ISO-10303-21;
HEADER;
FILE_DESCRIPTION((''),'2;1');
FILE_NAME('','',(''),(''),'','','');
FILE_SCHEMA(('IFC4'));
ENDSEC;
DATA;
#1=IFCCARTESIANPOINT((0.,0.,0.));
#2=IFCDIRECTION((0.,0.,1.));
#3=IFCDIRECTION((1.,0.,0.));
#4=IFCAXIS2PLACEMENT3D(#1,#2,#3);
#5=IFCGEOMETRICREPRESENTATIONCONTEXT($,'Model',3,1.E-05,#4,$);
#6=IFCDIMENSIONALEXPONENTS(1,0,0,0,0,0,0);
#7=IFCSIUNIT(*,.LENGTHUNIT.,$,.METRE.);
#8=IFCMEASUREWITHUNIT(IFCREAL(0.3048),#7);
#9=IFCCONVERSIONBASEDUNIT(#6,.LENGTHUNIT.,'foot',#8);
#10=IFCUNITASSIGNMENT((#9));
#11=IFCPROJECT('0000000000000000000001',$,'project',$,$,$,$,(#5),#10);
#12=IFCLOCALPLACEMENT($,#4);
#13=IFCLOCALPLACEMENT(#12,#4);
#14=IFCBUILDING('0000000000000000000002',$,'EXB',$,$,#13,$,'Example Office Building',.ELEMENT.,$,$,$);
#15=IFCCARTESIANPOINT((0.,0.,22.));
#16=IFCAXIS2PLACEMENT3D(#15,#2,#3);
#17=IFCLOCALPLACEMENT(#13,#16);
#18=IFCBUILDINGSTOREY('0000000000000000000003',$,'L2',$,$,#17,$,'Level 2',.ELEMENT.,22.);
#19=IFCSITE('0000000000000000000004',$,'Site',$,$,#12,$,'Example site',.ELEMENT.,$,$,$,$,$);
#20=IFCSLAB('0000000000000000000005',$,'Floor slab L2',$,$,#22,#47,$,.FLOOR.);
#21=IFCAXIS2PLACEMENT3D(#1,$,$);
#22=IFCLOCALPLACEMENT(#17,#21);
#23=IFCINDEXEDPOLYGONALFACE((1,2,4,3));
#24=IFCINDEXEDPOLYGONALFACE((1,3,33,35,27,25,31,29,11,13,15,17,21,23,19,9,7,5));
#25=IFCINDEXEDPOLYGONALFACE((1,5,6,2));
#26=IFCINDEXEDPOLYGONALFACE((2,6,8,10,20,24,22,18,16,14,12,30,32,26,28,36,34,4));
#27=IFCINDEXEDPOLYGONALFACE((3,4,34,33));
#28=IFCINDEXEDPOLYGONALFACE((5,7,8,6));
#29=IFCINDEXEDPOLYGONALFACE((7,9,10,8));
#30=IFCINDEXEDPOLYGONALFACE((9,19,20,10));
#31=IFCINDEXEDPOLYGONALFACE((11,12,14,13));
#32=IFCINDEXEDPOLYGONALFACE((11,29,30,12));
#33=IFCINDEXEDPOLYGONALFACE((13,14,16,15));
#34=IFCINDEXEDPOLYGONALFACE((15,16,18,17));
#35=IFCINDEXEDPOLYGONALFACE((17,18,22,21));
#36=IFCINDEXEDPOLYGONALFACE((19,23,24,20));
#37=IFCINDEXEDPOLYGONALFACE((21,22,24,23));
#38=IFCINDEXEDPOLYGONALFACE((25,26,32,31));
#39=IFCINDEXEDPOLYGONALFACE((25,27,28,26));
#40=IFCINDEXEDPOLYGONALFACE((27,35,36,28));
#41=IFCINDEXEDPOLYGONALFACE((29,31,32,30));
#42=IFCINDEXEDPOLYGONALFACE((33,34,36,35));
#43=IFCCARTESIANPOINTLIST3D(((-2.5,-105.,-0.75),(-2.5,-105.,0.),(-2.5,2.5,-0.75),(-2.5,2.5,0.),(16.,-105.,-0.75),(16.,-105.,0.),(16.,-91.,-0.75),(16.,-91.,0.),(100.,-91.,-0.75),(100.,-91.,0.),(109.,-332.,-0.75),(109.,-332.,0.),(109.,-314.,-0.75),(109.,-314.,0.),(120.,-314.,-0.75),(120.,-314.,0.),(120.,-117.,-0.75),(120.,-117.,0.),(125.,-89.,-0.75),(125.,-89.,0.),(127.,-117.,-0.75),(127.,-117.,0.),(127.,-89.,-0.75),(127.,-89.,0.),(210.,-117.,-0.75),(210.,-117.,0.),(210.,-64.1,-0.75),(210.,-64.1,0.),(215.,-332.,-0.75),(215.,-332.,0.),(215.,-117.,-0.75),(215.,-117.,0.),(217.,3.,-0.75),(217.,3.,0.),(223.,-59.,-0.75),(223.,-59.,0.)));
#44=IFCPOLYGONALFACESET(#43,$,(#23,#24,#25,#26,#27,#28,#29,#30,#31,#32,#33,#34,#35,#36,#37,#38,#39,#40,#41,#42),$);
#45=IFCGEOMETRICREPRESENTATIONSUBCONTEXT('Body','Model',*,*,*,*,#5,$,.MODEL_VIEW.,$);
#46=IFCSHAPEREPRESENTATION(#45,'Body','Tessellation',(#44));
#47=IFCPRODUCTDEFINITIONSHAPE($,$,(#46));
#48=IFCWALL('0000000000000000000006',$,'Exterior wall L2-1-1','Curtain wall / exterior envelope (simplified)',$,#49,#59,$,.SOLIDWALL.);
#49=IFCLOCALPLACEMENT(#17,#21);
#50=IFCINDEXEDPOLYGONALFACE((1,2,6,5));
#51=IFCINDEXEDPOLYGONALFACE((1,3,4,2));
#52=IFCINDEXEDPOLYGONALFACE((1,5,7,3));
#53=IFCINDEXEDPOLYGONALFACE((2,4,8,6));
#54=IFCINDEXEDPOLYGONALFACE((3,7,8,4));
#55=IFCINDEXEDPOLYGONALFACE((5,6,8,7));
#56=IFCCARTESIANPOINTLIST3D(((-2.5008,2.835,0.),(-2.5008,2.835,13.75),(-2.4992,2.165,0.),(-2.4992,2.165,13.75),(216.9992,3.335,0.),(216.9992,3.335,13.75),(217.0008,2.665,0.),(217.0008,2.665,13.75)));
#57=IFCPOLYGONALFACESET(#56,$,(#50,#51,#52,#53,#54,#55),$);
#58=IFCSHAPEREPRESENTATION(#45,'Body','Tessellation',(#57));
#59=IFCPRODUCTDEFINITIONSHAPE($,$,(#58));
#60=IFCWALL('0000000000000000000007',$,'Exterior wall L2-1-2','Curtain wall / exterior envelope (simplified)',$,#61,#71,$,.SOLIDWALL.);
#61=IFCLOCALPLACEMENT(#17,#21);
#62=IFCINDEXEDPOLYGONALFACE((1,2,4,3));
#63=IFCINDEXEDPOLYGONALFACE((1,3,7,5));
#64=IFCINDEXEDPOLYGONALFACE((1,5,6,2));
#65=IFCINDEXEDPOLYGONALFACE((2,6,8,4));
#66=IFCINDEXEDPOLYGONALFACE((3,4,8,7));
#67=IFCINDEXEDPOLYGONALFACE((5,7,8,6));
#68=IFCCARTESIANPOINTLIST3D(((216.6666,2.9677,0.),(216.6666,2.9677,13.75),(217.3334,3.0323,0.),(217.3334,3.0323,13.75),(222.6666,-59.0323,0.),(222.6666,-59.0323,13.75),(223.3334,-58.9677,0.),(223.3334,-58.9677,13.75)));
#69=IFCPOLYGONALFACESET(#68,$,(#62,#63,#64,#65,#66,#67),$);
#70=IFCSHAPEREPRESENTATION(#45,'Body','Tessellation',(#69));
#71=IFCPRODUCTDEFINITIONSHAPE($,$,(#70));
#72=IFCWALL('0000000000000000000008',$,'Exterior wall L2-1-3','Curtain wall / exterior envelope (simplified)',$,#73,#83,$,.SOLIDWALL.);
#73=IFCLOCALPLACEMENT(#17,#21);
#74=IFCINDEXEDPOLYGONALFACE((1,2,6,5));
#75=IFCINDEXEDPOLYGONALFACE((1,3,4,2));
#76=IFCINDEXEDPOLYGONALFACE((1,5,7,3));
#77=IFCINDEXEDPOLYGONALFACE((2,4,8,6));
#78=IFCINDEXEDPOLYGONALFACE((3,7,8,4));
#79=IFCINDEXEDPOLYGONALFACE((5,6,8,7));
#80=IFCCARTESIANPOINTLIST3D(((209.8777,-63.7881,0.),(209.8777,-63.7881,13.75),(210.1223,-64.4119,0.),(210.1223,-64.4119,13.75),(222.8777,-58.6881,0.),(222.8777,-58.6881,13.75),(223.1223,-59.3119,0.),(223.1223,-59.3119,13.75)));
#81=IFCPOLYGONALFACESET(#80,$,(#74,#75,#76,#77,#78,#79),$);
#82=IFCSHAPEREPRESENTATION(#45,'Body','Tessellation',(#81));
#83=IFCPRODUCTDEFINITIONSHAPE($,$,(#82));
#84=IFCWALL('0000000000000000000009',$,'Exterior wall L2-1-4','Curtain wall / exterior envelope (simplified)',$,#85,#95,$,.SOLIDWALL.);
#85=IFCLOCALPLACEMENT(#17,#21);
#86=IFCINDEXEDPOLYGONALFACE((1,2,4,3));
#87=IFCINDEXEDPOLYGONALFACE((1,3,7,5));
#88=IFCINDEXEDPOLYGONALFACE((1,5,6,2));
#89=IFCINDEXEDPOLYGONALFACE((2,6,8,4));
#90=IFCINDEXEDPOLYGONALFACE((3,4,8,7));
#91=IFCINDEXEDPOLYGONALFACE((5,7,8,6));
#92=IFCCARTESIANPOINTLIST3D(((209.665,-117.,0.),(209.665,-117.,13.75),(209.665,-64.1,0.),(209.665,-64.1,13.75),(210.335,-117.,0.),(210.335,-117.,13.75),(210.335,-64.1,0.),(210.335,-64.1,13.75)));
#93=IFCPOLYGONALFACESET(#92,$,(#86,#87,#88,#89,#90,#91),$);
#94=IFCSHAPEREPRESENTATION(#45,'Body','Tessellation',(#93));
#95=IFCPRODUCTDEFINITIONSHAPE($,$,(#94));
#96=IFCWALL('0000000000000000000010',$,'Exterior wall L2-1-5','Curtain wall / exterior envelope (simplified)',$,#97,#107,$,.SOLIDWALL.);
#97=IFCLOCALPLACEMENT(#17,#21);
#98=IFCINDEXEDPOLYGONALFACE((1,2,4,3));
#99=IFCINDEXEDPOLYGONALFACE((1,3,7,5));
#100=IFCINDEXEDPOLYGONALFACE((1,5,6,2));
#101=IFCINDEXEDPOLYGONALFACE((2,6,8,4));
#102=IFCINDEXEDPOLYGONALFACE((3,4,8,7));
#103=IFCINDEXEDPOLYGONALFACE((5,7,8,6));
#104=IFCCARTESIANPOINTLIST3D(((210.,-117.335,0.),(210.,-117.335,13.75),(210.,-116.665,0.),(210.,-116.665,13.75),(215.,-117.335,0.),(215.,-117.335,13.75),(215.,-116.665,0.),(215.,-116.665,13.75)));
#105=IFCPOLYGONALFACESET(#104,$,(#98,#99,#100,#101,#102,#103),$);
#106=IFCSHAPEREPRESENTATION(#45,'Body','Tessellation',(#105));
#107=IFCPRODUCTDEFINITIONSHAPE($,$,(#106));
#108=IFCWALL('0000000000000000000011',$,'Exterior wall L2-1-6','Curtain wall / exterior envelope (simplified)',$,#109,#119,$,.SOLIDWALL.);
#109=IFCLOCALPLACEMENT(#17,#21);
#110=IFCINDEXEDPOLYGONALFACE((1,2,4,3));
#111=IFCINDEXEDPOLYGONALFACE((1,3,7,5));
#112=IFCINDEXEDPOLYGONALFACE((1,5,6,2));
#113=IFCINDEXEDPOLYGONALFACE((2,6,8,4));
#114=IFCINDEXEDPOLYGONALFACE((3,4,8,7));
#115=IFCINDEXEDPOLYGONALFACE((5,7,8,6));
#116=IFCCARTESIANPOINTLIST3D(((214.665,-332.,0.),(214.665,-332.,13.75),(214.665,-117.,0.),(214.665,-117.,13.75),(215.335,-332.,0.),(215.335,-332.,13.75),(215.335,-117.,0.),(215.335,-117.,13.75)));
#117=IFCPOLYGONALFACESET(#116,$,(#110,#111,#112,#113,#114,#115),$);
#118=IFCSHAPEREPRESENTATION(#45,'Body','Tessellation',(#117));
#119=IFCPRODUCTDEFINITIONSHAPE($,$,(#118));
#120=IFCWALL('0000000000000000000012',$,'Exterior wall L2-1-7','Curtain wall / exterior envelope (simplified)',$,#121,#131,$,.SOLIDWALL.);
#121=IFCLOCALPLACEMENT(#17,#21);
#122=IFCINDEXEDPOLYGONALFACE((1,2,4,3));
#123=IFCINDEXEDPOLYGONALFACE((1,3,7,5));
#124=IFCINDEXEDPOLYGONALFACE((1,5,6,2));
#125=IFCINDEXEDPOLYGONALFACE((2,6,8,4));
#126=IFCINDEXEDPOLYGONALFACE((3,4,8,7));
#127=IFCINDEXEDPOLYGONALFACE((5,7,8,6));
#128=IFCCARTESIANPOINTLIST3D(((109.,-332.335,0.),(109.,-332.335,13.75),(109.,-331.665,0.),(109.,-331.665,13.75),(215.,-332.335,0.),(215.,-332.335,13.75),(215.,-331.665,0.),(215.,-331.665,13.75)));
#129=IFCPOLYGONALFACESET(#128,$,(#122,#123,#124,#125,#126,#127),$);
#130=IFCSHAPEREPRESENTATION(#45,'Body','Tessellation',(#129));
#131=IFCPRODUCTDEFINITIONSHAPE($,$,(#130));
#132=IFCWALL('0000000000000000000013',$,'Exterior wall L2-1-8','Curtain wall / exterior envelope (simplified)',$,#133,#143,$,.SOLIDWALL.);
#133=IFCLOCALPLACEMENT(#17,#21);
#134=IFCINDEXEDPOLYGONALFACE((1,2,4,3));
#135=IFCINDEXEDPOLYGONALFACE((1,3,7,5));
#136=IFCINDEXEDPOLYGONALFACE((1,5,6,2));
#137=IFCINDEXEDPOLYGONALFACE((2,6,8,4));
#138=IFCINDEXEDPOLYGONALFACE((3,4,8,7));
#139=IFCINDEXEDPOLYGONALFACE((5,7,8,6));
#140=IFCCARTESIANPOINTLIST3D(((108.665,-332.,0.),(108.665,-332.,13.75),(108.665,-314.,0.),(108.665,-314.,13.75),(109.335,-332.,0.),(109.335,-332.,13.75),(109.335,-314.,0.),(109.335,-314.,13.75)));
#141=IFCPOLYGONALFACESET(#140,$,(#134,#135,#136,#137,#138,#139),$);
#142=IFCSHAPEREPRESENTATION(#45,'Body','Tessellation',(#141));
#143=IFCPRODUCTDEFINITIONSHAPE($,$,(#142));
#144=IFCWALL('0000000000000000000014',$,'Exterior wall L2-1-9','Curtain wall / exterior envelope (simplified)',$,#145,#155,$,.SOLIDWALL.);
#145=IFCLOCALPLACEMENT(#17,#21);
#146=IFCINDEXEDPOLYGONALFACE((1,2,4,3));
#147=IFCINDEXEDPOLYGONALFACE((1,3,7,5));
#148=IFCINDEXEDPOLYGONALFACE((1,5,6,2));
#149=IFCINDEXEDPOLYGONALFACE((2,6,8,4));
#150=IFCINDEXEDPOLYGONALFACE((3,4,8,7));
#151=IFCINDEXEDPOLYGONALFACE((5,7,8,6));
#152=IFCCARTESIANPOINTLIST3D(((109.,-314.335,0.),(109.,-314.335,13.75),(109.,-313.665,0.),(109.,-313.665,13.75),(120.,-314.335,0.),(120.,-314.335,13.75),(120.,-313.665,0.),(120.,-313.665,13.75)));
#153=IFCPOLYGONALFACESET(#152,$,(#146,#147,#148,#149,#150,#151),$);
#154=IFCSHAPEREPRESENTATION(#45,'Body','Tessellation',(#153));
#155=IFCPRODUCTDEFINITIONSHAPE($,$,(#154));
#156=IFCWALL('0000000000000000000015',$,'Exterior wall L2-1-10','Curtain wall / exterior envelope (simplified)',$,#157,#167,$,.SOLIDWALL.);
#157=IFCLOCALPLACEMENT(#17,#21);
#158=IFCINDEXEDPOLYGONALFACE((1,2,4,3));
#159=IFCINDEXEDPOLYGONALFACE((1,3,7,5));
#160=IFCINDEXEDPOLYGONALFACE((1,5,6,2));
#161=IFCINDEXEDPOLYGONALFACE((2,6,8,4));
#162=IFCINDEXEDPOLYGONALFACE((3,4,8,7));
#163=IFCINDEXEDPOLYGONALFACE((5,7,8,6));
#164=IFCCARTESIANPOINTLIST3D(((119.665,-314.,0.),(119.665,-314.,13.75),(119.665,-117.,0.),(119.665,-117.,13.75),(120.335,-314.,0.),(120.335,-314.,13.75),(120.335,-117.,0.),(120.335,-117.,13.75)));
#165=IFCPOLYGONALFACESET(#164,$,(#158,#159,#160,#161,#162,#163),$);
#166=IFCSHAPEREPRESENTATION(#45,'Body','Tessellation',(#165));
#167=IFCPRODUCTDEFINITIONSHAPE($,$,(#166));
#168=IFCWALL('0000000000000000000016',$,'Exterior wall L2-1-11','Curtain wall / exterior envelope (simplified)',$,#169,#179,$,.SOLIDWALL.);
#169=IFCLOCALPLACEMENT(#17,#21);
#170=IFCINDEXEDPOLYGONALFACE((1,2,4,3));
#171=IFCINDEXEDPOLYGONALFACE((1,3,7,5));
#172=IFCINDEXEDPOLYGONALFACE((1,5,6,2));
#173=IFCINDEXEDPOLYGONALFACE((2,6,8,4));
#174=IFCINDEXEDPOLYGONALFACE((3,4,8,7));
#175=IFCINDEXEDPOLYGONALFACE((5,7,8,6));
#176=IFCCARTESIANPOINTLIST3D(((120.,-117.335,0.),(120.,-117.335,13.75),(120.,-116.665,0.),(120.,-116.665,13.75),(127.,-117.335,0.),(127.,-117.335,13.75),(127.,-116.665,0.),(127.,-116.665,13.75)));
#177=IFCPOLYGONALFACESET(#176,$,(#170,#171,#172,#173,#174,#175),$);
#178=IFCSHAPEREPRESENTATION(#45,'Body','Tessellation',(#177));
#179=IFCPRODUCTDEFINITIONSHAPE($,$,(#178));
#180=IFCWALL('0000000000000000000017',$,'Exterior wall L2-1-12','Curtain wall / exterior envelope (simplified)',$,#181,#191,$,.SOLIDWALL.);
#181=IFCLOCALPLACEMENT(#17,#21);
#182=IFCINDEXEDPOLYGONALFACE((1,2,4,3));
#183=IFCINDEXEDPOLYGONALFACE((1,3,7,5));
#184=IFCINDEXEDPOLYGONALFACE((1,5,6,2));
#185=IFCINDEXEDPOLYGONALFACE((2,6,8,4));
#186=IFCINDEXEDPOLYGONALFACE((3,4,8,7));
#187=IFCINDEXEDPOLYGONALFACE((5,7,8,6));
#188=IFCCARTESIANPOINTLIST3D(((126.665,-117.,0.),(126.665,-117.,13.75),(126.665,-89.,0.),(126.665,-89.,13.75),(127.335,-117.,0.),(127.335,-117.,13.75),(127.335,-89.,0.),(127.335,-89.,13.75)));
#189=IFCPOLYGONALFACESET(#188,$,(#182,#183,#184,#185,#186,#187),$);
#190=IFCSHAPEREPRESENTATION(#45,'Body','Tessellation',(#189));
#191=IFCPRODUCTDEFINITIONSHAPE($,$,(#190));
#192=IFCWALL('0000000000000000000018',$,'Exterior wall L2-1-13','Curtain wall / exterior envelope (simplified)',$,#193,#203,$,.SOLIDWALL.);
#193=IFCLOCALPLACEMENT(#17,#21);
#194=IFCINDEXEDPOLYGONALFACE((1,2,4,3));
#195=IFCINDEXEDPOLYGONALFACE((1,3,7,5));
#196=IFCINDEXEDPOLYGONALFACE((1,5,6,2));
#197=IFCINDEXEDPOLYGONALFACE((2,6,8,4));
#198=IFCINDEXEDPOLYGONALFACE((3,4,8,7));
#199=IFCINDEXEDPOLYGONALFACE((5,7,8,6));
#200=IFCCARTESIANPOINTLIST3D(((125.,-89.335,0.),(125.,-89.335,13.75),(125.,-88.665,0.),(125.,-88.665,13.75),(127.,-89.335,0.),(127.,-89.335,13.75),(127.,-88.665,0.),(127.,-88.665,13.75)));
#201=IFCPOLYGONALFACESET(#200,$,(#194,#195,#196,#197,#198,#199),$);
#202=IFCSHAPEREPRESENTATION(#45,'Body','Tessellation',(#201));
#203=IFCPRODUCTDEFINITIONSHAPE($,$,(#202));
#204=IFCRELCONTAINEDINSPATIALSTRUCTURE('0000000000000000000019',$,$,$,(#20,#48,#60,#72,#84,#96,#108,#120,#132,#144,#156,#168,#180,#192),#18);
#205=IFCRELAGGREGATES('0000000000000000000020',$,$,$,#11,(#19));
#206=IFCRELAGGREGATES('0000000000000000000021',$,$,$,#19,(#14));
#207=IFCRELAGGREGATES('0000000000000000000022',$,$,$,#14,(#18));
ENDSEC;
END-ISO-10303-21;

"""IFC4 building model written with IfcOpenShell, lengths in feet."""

from ifc_helpers import new_model, entity, si_unit, converted_unit, frame, frame_2d, origin, origin_with_axes, place, context, subcontext, project, spatial, polyline, rectangle, outline, extrude, element, save


model = new_model("IFC4")

# Units and contexts
model_context = context("Model", 3, precision=1e-05, world=origin_with_axes())
body_context = subcontext(model_context, "Body", "Model", "MODEL_VIEW")
ifc_project = project(units=[converted_unit("LENGTHUNIT", "foot", entity("IfcReal", 0.3048), si_unit("LENGTHUNIT", "METRE"), dimensions=[1, 0, 0, 0, 0, 0, 0])], contexts=[model_context])

# Site, building, storey
site_placement = place(None, origin_with_axes())
site = spatial("IfcSite", under=ifc_project, at=site_placement, Name="Site", LongName="Example site", CompositionType="ELEMENT")
building_placement = place(site_placement, origin_with_axes())
building = spatial("IfcBuilding", under=site, at=building_placement, Name="EXB", LongName="Example Office Building", CompositionType="ELEMENT")
storey_placement = place(building_placement, frame((0.0, 0.0, 22.0), z_axis=(0.0, 0.0, 1.0), x_axis=(1.0, 0.0, 0.0)))
storey = spatial("IfcBuildingStorey", under=building, at=storey_placement, Name="L2", LongName="Level 2", CompositionType="ELEMENT", Elevation=22.0)

# Slab
slab_placement = place(storey_placement, origin_with_axes())
element("IfcSlab", 1, at=slab_placement, inside=storey, Name="Floor slab L2", PredefinedType="FLOOR", context=body_context, shape_type="SweptSolid", body=[
    extrude(outline(polyline([(-2.5, 2.5), (217.0, 3.0), (223.0, -59.0), (210.0, -64.1), (210.0, -117.0), (215.0, -117.0), (215.0, -332.0), (109.0, -332.0), (109.0, -314.0), (120.0, -314.0), (120.0, -117.0), (127.0, -117.0), (127.0, -89.0), (125.0, -89.0), (100.0, -91.0), (16.0, -91.0), (16.0, -105.0), (-2.5, -105.0), (-2.5, 2.5)])), frame((0.0, 0.0, -0.75)), (0.0, 0.0, 1.0), 0.75),
])

# Walls
wall_1_placement = place(storey_placement, frame((-2.5, 2.5, 0.0), z_axis=(0.0, 0.0, 1.0), x_axis=(0.999997, 0.002278, 0.0)))
element("IfcWall", 2, at=wall_1_placement, inside=storey, Name="Exterior wall L2-1-1", Description="Curtain wall / exterior envelope (simplified)", PredefinedType="SOLIDWALL", context=body_context, shape_type="SweptSolid", body=[
    extrude(rectangle(XDim=219.5006, YDim=0.67, at=frame_2d((109.7503, 0.0))), origin(), (0.0, 0.0, 1.0), 13.75),
])
wall_2_placement = place(storey_placement, frame((217.0, 3.0, 0.0), z_axis=(0.0, 0.0, 1.0), x_axis=(0.096324, -0.99535, 0.0)))
element("IfcWall", 3, at=wall_2_placement, inside=storey, Name="Exterior wall L2-1-2", Description="Curtain wall / exterior envelope (simplified)", PredefinedType="SOLIDWALL", context=body_context, shape_type="SweptSolid", body=[
    extrude(rectangle(XDim=62.2896, YDim=0.67, at=frame_2d((31.1448, 0.0))), origin(), (0.0, 0.0, 1.0), 13.75),
])
wall_3_placement = place(storey_placement, frame((223.0, -59.0, 0.0), z_axis=(0.0, 0.0, 1.0), x_axis=(-0.930925, -0.365209, 0.0)))
element("IfcWall", 4, at=wall_3_placement, inside=storey, Name="Exterior wall L2-1-3", Description="Curtain wall / exterior envelope (simplified)", PredefinedType="SOLIDWALL", context=body_context, shape_type="SweptSolid", body=[
    extrude(rectangle(XDim=13.9646, YDim=0.67, at=frame_2d((6.9823, 0.0))), origin(), (0.0, 0.0, 1.0), 13.75),
])
wall_4_placement = place(storey_placement, frame((210.0, -64.1, 0.0), z_axis=(0.0, 0.0, 1.0), x_axis=(0.0, -1.0, 0.0)))
element("IfcWall", 5, at=wall_4_placement, inside=storey, Name="Exterior wall L2-1-4", Description="Curtain wall / exterior envelope (simplified)", PredefinedType="SOLIDWALL", context=body_context, shape_type="SweptSolid", body=[
    extrude(rectangle(XDim=52.9, YDim=0.67, at=frame_2d((26.45, 0.0))), origin(), (0.0, 0.0, 1.0), 13.75),
])
wall_5_placement = place(storey_placement, frame((210.0, -117.0, 0.0), z_axis=(0.0, 0.0, 1.0), x_axis=(1.0, 0.0, 0.0)))
element("IfcWall", 6, at=wall_5_placement, inside=storey, Name="Exterior wall L2-1-5", Description="Curtain wall / exterior envelope (simplified)", PredefinedType="SOLIDWALL", context=body_context, shape_type="SweptSolid", body=[
    extrude(rectangle(XDim=5.0, YDim=0.67, at=frame_2d((2.5, 0.0))), origin(), (0.0, 0.0, 1.0), 13.75),
])
wall_6_placement = place(storey_placement, frame((215.0, -117.0, 0.0), z_axis=(0.0, 0.0, 1.0), x_axis=(0.0, -1.0, 0.0)))
element("IfcWall", 7, at=wall_6_placement, inside=storey, Name="Exterior wall L2-1-6", Description="Curtain wall / exterior envelope (simplified)", PredefinedType="SOLIDWALL", context=body_context, shape_type="SweptSolid", body=[
    extrude(rectangle(XDim=215.0, YDim=0.67, at=frame_2d((107.5, 0.0))), origin(), (0.0, 0.0, 1.0), 13.75),
])
wall_7_placement = place(storey_placement, frame((215.0, -332.0, 0.0), z_axis=(0.0, 0.0, 1.0), x_axis=(-1.0, 0.0, 0.0)))
element("IfcWall", 8, at=wall_7_placement, inside=storey, Name="Exterior wall L2-1-7", Description="Curtain wall / exterior envelope (simplified)", PredefinedType="SOLIDWALL", context=body_context, shape_type="SweptSolid", body=[
    extrude(rectangle(XDim=106.0, YDim=0.67, at=frame_2d((53.0, 0.0))), origin(), (0.0, 0.0, 1.0), 13.75),
])
wall_8_placement = place(storey_placement, frame((109.0, -332.0, 0.0), z_axis=(0.0, 0.0, 1.0), x_axis=(0.0, 1.0, 0.0)))
element("IfcWall", 9, at=wall_8_placement, inside=storey, Name="Exterior wall L2-1-8", Description="Curtain wall / exterior envelope (simplified)", PredefinedType="SOLIDWALL", context=body_context, shape_type="SweptSolid", body=[
    extrude(rectangle(XDim=18.0, YDim=0.67, at=frame_2d((9.0, 0.0))), origin(), (0.0, 0.0, 1.0), 13.75),
])
wall_9_placement = place(storey_placement, frame((109.0, -314.0, 0.0), z_axis=(0.0, 0.0, 1.0), x_axis=(1.0, 0.0, 0.0)))
element("IfcWall", 10, at=wall_9_placement, inside=storey, Name="Exterior wall L2-1-9", Description="Curtain wall / exterior envelope (simplified)", PredefinedType="SOLIDWALL", context=body_context, shape_type="SweptSolid", body=[
    extrude(rectangle(XDim=11.0, YDim=0.67, at=frame_2d((5.5, 0.0))), origin(), (0.0, 0.0, 1.0), 13.75),
])
wall_10_placement = place(storey_placement, frame((120.0, -314.0, 0.0), z_axis=(0.0, 0.0, 1.0), x_axis=(0.0, 1.0, 0.0)))
element("IfcWall", 11, at=wall_10_placement, inside=storey, Name="Exterior wall L2-1-10", Description="Curtain wall / exterior envelope (simplified)", PredefinedType="SOLIDWALL", context=body_context, shape_type="SweptSolid", body=[
    extrude(rectangle(XDim=197.0, YDim=0.67, at=frame_2d((98.5, 0.0))), origin(), (0.0, 0.0, 1.0), 13.75),
])
wall_11_placement = place(storey_placement, frame((120.0, -117.0, 0.0), z_axis=(0.0, 0.0, 1.0), x_axis=(1.0, 0.0, 0.0)))
element("IfcWall", 12, at=wall_11_placement, inside=storey, Name="Exterior wall L2-1-11", Description="Curtain wall / exterior envelope (simplified)", PredefinedType="SOLIDWALL", context=body_context, shape_type="SweptSolid", body=[
    extrude(rectangle(XDim=7.0, YDim=0.67, at=frame_2d((3.5, 0.0))), origin(), (0.0, 0.0, 1.0), 13.75),
])
wall_12_placement = place(storey_placement, frame((127.0, -117.0, 0.0), z_axis=(0.0, 0.0, 1.0), x_axis=(0.0, 1.0, 0.0)))
element("IfcWall", 13, at=wall_12_placement, inside=storey, Name="Exterior wall L2-1-12", Description="Curtain wall / exterior envelope (simplified)", PredefinedType="SOLIDWALL", context=body_context, shape_type="SweptSolid", body=[
    extrude(rectangle(XDim=28.0, YDim=0.67, at=frame_2d((14.0, 0.0))), origin(), (0.0, 0.0, 1.0), 13.75),
])
wall_13_placement = place(storey_placement, frame((127.0, -89.0, 0.0), z_axis=(0.0, 0.0, 1.0), x_axis=(-1.0, 0.0, 0.0)))
element("IfcWall", 14, at=wall_13_placement, inside=storey, Name="Exterior wall L2-1-13", Description="Curtain wall / exterior envelope (simplified)", PredefinedType="SOLIDWALL", context=body_context, shape_type="SweptSolid", body=[
    extrude(rectangle(XDim=2.0, YDim=0.67, at=frame_2d((1.0, 0.0))), origin(), (0.0, 0.0, 1.0), 13.75),
])

save(model, "model.ifc")
